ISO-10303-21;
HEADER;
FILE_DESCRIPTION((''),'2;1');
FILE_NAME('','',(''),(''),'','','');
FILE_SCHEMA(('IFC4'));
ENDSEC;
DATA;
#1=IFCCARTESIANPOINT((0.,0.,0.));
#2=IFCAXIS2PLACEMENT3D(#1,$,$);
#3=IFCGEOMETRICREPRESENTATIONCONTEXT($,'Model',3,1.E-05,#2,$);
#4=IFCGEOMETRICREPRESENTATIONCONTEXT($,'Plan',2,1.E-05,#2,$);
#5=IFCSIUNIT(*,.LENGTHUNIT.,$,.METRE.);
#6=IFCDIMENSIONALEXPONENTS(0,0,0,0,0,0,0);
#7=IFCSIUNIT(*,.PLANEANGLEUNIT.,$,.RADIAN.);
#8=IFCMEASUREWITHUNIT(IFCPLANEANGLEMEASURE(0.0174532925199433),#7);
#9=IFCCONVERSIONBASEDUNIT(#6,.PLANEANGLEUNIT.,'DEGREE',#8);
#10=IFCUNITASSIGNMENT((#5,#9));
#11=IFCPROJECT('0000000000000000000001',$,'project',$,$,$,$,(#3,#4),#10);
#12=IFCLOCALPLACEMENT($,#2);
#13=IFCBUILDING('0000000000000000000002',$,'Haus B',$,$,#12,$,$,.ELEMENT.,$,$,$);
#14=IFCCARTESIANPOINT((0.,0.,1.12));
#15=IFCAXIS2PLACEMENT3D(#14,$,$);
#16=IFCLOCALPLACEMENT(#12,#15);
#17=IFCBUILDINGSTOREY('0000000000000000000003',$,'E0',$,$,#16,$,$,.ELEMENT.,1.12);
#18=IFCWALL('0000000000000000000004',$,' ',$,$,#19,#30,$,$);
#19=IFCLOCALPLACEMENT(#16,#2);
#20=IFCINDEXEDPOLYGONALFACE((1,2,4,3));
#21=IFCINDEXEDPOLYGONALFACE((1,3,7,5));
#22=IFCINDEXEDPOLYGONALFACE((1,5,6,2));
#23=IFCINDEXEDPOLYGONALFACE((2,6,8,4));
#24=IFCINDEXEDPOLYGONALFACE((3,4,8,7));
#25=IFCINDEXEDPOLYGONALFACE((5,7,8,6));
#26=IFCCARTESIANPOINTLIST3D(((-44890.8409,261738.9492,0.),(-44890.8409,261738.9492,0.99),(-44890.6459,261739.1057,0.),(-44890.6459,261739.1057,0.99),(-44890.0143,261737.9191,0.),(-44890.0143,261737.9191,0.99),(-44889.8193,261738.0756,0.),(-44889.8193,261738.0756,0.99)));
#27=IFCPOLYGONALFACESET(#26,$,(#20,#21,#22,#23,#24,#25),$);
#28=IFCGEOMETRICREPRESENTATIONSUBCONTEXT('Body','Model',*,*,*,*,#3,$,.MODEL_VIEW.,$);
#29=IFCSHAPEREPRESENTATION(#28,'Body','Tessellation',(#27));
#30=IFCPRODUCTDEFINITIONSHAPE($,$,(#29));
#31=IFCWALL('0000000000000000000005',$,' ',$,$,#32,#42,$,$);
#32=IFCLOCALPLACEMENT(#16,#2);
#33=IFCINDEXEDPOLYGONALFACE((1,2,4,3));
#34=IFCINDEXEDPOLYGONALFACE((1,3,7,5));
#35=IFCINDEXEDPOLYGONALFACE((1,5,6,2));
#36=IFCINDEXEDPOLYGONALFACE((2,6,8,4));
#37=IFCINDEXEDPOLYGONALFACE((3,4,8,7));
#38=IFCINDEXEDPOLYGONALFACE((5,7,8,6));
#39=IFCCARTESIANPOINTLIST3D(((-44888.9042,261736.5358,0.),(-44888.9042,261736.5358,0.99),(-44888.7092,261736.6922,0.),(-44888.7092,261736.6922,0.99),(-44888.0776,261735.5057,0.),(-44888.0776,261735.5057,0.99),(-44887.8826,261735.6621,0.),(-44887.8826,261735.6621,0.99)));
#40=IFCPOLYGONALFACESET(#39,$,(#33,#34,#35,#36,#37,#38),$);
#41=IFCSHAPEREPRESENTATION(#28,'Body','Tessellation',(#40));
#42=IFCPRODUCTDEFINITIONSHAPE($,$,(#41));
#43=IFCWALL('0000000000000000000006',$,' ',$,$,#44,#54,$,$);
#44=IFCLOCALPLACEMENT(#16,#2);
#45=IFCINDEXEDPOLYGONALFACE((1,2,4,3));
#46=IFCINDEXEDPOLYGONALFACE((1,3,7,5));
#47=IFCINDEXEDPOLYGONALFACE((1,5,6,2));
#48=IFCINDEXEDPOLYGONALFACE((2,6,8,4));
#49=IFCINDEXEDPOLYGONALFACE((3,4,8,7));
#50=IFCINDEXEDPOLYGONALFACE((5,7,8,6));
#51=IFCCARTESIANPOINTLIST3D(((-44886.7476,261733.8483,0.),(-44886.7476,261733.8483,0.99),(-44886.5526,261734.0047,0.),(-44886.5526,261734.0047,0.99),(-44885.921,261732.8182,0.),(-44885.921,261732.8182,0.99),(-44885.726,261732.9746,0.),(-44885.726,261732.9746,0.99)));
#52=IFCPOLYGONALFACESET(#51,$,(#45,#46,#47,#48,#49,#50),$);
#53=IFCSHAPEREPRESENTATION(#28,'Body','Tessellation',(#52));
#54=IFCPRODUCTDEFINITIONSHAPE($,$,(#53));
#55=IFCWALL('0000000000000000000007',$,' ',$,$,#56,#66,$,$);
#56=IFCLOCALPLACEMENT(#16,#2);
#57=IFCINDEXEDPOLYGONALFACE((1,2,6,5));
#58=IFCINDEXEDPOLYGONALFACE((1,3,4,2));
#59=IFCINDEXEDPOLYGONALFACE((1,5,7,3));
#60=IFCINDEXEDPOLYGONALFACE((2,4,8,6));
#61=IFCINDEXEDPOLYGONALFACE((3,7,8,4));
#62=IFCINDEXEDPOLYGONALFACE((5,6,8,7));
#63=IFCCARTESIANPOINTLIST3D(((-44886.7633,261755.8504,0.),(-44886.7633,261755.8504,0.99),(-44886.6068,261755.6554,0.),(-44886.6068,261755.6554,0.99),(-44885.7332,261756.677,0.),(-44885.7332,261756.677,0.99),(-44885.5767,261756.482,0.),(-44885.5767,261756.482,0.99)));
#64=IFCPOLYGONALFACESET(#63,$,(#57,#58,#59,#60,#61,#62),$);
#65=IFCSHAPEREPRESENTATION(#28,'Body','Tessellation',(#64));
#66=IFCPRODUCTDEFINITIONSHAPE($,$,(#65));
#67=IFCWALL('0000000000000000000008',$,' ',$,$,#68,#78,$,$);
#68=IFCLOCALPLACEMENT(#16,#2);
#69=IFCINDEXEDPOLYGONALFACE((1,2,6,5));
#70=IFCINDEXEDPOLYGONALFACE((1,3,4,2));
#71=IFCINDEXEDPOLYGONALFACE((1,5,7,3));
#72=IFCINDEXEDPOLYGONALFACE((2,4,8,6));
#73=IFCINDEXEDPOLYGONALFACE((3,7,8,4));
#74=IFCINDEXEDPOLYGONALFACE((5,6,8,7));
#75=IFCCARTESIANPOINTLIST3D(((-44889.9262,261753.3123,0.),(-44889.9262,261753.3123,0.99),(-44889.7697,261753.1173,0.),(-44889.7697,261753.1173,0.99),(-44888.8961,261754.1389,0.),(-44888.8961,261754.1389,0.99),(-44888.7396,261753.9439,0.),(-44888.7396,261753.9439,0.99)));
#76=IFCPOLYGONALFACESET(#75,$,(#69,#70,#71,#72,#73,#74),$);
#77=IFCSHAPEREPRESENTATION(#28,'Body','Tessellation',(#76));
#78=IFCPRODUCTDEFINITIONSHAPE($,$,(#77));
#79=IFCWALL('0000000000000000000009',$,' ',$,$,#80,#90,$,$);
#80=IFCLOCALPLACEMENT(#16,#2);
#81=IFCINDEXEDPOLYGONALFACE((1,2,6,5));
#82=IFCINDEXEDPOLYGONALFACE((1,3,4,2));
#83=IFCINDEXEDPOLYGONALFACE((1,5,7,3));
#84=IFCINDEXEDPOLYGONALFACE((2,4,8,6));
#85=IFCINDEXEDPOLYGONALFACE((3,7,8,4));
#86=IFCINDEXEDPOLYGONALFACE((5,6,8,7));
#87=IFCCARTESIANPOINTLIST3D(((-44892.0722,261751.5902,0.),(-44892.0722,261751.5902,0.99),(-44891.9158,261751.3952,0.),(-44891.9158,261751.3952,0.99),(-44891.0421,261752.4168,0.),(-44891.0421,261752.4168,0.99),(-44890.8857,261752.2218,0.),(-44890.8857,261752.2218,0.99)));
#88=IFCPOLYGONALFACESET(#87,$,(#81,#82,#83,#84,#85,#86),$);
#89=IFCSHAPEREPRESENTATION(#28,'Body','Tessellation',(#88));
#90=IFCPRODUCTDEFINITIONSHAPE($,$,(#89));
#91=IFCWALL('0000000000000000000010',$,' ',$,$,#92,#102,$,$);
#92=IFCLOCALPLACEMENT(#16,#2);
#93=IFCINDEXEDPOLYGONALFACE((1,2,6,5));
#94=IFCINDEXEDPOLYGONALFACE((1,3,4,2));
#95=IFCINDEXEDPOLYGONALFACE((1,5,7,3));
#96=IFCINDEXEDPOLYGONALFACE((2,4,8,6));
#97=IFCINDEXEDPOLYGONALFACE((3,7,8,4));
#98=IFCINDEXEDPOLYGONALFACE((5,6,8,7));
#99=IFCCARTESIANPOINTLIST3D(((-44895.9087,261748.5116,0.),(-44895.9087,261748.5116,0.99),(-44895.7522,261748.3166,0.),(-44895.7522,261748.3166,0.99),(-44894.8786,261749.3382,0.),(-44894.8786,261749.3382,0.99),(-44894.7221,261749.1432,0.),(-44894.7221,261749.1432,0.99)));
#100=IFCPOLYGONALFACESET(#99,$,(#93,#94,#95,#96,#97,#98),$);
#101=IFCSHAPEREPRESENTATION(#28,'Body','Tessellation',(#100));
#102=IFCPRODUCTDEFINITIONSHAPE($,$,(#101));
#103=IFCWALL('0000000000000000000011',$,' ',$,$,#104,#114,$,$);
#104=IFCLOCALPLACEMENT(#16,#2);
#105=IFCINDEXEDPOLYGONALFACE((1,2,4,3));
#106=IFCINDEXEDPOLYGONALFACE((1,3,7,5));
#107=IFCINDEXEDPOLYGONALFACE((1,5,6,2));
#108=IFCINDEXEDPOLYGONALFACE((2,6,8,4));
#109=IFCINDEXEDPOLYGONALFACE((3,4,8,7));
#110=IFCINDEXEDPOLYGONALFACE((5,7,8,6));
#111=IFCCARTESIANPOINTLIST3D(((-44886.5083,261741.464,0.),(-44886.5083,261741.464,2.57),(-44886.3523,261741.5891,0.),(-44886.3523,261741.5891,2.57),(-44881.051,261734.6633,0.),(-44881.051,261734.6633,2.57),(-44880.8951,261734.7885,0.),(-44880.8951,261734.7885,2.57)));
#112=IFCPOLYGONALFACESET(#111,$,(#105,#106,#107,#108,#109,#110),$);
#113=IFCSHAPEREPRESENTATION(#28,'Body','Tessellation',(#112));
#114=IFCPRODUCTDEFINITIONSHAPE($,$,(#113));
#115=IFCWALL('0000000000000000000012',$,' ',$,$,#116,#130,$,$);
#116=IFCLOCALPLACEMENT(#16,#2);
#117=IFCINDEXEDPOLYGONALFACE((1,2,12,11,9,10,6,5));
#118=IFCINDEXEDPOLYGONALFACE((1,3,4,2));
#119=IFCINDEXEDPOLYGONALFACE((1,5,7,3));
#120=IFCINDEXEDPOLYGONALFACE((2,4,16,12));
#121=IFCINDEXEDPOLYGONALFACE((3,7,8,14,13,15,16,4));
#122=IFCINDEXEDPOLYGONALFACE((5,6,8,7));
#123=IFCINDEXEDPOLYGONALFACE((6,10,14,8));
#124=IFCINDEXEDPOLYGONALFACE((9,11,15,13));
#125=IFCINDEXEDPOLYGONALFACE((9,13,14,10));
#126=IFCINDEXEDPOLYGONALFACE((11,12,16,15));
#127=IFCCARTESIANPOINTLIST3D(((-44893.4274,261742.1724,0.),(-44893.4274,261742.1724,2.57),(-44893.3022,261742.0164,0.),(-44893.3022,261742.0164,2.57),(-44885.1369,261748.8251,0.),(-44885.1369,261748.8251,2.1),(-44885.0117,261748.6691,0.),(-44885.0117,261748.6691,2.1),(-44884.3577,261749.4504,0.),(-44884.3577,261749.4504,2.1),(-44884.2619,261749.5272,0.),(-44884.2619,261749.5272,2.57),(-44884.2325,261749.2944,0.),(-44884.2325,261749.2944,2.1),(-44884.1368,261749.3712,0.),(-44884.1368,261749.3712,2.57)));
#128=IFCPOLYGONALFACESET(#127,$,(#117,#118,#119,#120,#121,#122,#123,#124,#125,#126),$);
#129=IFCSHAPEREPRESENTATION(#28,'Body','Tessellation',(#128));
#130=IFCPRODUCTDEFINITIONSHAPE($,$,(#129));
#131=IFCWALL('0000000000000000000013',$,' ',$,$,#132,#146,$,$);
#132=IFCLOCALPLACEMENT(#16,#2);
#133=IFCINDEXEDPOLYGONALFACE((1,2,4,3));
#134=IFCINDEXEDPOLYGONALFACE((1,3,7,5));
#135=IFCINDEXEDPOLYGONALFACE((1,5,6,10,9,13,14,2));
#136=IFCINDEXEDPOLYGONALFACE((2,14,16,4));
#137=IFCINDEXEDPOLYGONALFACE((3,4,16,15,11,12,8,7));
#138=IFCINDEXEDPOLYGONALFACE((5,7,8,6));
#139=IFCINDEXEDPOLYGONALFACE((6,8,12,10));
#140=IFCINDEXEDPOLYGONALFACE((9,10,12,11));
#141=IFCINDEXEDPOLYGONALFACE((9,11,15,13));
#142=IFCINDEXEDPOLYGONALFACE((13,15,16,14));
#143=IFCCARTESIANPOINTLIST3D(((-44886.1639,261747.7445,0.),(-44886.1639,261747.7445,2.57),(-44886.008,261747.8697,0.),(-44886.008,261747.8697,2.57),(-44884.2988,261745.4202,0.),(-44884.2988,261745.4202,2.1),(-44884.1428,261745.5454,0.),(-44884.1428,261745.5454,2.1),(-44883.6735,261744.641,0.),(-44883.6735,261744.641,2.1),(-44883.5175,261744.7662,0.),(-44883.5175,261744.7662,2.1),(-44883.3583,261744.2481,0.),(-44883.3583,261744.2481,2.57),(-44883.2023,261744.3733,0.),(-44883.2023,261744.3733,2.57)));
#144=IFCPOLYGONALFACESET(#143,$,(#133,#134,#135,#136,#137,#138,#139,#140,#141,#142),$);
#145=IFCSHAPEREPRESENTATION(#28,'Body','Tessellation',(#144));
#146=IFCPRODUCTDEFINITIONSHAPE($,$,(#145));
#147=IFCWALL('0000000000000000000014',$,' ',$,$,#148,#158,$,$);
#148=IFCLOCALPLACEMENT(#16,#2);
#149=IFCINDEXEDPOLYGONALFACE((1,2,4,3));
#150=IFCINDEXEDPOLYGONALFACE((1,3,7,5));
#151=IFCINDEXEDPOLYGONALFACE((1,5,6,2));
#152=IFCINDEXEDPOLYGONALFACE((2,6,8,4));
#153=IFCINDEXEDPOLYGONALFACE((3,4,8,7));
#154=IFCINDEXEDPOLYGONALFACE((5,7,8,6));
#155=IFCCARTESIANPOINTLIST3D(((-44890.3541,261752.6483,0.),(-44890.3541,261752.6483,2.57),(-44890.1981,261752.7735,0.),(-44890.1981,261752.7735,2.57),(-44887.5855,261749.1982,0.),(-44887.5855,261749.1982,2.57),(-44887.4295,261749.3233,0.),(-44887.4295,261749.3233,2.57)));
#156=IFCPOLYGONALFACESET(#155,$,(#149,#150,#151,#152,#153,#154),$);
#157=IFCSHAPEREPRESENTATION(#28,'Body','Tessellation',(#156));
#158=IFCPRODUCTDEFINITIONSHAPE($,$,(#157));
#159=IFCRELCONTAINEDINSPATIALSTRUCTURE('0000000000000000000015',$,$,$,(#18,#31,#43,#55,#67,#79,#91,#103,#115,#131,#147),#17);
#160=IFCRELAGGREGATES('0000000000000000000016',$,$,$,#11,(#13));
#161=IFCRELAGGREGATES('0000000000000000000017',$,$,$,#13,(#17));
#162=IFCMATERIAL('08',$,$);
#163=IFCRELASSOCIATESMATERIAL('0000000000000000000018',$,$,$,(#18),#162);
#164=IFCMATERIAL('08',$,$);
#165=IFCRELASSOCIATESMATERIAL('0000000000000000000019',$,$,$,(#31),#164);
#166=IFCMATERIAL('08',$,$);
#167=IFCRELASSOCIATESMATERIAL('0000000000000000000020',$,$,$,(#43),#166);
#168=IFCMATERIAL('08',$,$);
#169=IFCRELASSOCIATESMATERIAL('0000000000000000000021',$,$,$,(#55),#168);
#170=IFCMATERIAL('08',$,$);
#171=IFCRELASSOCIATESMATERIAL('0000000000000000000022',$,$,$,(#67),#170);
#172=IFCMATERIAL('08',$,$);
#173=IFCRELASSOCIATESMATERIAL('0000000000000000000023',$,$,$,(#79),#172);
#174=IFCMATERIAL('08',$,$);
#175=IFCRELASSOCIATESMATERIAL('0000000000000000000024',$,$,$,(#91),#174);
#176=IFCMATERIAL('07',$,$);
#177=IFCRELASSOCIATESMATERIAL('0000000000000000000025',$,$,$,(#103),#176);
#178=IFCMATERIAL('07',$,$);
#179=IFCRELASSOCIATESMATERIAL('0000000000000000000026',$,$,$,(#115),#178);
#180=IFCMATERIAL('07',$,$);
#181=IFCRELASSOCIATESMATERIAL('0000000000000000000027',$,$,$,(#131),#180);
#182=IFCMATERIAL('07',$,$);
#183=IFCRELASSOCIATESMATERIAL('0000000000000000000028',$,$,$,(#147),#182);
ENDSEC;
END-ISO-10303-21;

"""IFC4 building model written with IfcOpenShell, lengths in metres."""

from ifc_helpers import new_model, entity, si_unit, converted_unit, frame, frame_2d, origin, origin_with_axes, place, context, subcontext, project, spatial, polyline, rectangle, outline, extrude, material, element, save


model = new_model("IFC4")

# Units and contexts
model_context = context("Model", 3, precision=1e-05, world=origin())
plan_context = context("Plan", 2, precision=1e-05, world=origin())
body_context = subcontext(model_context, "Body", "Model", "MODEL_VIEW")
ifc_project = project(units=[si_unit("LENGTHUNIT", "METRE"), converted_unit("PLANEANGLEUNIT", "DEGREE", entity("IfcPlaneAngleMeasure", 0.0174532925199433), si_unit("PLANEANGLEUNIT", "RADIAN"), dimensions=[0, 0, 0, 0, 0, 0, 0])], contexts=[model_context, plan_context])

# Building, storey
building_placement = place(None, origin())
building = spatial("IfcBuilding", under=ifc_project, at=building_placement, Name="Haus B", CompositionType="ELEMENT")
storey_placement = place(building_placement, frame((0.0, 0.0, 1.12)))
storey = spatial("IfcBuildingStorey", under=building, at=storey_placement, Name="E0", CompositionType="ELEMENT", Elevation=1.12)

# Walls
ifc_material_1 = material(Name="08")
wall_1_placement = place(storey_placement, frame((-44889.8193, 261738.0756, 0.0), z_axis=(0.0, 0.0, 1.0), x_axis=(-0.625861, 0.779935, 0.0)))
element("IfcWall", 1, at=wall_1_placement, inside=storey, material=ifc_material_1, Name=" ", context=body_context, shape_type="SweptSolid", body=[
    extrude(rectangle(XDim=1.3207, YDim=0.25, at=frame_2d((0.6604, 0.125), x_axis=(1.0, 0.0))), origin_with_axes(), (0.0, 0.0, 1.0), 0.99),
])
ifc_material_2 = material(Name="08")
wall_2_placement = place(storey_placement, frame((-44887.8826, 261735.6621, 0.0), z_axis=(0.0, 0.0, 1.0), x_axis=(-0.625861, 0.779935, 0.0)))
element("IfcWall", 2, at=wall_2_placement, inside=storey, material=ifc_material_2, Name=" ", context=body_context, shape_type="SweptSolid", body=[
    extrude(rectangle(XDim=1.3207, YDim=0.25, at=frame_2d((0.6604, 0.125), x_axis=(1.0, 0.0))), origin_with_axes(), (0.0, 0.0, 1.0), 0.99),
])
ifc_material_3 = material(Name="08")
wall_3_placement = place(storey_placement, frame((-44885.726, 261732.9746, 0.0), z_axis=(0.0, 0.0, 1.0), x_axis=(-0.625861, 0.779935, 0.0)))
element("IfcWall", 3, at=wall_3_placement, inside=storey, material=ifc_material_3, Name=" ", context=body_context, shape_type="SweptSolid", body=[
    extrude(rectangle(XDim=1.3207, YDim=0.25, at=frame_2d((0.6604, 0.125), x_axis=(1.0, 0.0))), origin_with_axes(), (0.0, 0.0, 1.0), 0.99),
])
ifc_material_4 = material(Name="08")
wall_4_placement = place(storey_placement, frame((-44886.6068, 261755.6554, 0.0), z_axis=(0.0, 0.0, 1.0), x_axis=(0.779935, 0.625861, 0.0)))
element("IfcWall", 4, at=wall_4_placement, inside=storey, material=ifc_material_4, Name=" ", context=body_context, shape_type="SweptSolid", body=[
    extrude(rectangle(XDim=1.3207, YDim=0.25, at=frame_2d((0.6604, 0.125), x_axis=(1.0, 0.0))), origin_with_axes(), (0.0, 0.0, 1.0), 0.99),
])
ifc_material_5 = material(Name="08")
wall_5_placement = place(storey_placement, frame((-44889.7697, 261753.1173, 0.0), z_axis=(0.0, 0.0, 1.0), x_axis=(0.779935, 0.625861, 0.0)))
element("IfcWall", 5, at=wall_5_placement, inside=storey, material=ifc_material_5, Name=" ", context=body_context, shape_type="SweptSolid", body=[
    extrude(rectangle(XDim=1.3207, YDim=0.25, at=frame_2d((0.6604, 0.125), x_axis=(1.0, 0.0))), origin_with_axes(), (0.0, 0.0, 1.0), 0.99),
])
ifc_material_6 = material(Name="08")
wall_6_placement = place(storey_placement, frame((-44891.9158, 261751.3952, 0.0), z_axis=(0.0, 0.0, 1.0), x_axis=(0.779935, 0.625861, 0.0)))
element("IfcWall", 6, at=wall_6_placement, inside=storey, material=ifc_material_6, Name=" ", context=body_context, shape_type="SweptSolid", body=[
    extrude(rectangle(XDim=1.3207, YDim=0.25, at=frame_2d((0.6604, 0.125), x_axis=(1.0, 0.0))), origin_with_axes(), (0.0, 0.0, 1.0), 0.99),
])
ifc_material_7 = material(Name="08")
wall_7_placement = place(storey_placement, frame((-44895.7522, 261748.3166, 0.0), z_axis=(0.0, 0.0, 1.0), x_axis=(0.779935, 0.625861, 0.0)))
element("IfcWall", 7, at=wall_7_placement, inside=storey, material=ifc_material_7, Name=" ", context=body_context, shape_type="SweptSolid", body=[
    extrude(rectangle(XDim=1.3207, YDim=0.25, at=frame_2d((0.6604, 0.125), x_axis=(1.0, 0.0))), origin_with_axes(), (0.0, 0.0, 1.0), 0.99),
])
ifc_material_8 = material(Name="07")
wall_8_placement = place(storey_placement, frame((-44886.5083, 261741.464, 0.0), z_axis=(0.0, 0.0, 1.0), x_axis=(0.625861, -0.779935, 0.0)))
element("IfcWall", 8, at=wall_8_placement, inside=storey, material=ifc_material_8, Name=" ", context=body_context, shape_type="SweptSolid", body=[
    extrude(rectangle(XDim=8.7195, YDim=0.2, at=frame_2d((4.3598, 0.1), x_axis=(1.0, 0.0))), origin_with_axes(), (0.0, 0.0, 1.0), 2.57),
])

# Walls, openings
ifc_material_9 = material(Name="07")
wall_9_placement = place(storey_placement, frame((-44893.3022, 261742.0164, 0.0), z_axis=(0.0, 0.0, 1.0), x_axis=(0.779935, 0.625861, 0.0)))
wall_9 = element("IfcWall", 9, at=wall_9_placement, inside=storey, material=ifc_material_9, Name=" ", context=body_context, shape_type="SweptSolid", body=[
    extrude(rectangle(XDim=11.7515, YDim=0.2, at=frame_2d((5.8758, 0.1), x_axis=(1.0, 0.0))), origin_with_axes(), (0.0, 0.0, 1.0), 2.57),
])
opening_1_placement = place(wall_9_placement, frame((10.6297, 0.0, 0.0), z_axis=(0.0, 1.0, 0.0), x_axis=(0.0, 0.0, 1.0)))
element("IfcOpeningElement", 10, at=opening_1_placement, cuts=wall_9, ObjectType="Opening", context=body_context, shape_type="SweptSolid", body=[
    extrude(outline(polyline([(0.0, 0.999), (2.1, 0.999), (2.1, 0.0), (0.0, 0.0), (0.0, 0.999)])), origin_with_axes(), (0.0, 0.0, 1.0), 0.2),
])
ifc_material_10 = material(Name="07")
wall_10_placement = place(storey_placement, frame((-44886.1639, 261747.7445, 0.0), z_axis=(0.0, 0.0, 1.0), x_axis=(0.625861, -0.779935, 0.0)))
wall_10 = element("IfcWall", 11, at=wall_10_placement, inside=storey, material=ifc_material_10, Name=" ", context=body_context, shape_type="SweptSolid", body=[
    extrude(rectangle(XDim=4.4829, YDim=0.2, at=frame_2d((2.2415, 0.1), x_axis=(1.0, 0.0))), origin_with_axes(), (0.0, 0.0, 1.0), 2.57),
])
opening_2_placement = place(wall_10_placement, frame((3.9792, 0.2, 0.0), z_axis=(0.0, -1.0, 0.0), x_axis=(0.0, 0.0, 1.0)))
element("IfcOpeningElement", 12, at=opening_2_placement, cuts=wall_10, ObjectType="Opening", context=body_context, shape_type="SweptSolid", body=[
    extrude(outline(polyline([(0.0, 0.999), (2.1, 0.999), (2.1, 0.0), (0.0, 0.0), (0.0, 0.999)])), origin_with_axes(), (0.0, 0.0, 1.0), 0.2),
])

# Wall
ifc_material_11 = material(Name="07")
wall_11_placement = place(storey_placement, frame((-44890.3541, 261752.6483, 0.0), z_axis=(0.0, 0.0, 1.0), x_axis=(0.625861, -0.779935, 0.0)))
element("IfcWall", 13, at=wall_11_placement, inside=storey, material=ifc_material_11, Name=" ", context=body_context, shape_type="SweptSolid", body=[
    extrude(rectangle(XDim=4.4237, YDim=0.2, at=frame_2d((2.2118, 0.1), x_axis=(1.0, 0.0))), origin_with_axes(), (0.0, 0.0, 1.0), 2.57),
])

save(model, "model.ifc")
